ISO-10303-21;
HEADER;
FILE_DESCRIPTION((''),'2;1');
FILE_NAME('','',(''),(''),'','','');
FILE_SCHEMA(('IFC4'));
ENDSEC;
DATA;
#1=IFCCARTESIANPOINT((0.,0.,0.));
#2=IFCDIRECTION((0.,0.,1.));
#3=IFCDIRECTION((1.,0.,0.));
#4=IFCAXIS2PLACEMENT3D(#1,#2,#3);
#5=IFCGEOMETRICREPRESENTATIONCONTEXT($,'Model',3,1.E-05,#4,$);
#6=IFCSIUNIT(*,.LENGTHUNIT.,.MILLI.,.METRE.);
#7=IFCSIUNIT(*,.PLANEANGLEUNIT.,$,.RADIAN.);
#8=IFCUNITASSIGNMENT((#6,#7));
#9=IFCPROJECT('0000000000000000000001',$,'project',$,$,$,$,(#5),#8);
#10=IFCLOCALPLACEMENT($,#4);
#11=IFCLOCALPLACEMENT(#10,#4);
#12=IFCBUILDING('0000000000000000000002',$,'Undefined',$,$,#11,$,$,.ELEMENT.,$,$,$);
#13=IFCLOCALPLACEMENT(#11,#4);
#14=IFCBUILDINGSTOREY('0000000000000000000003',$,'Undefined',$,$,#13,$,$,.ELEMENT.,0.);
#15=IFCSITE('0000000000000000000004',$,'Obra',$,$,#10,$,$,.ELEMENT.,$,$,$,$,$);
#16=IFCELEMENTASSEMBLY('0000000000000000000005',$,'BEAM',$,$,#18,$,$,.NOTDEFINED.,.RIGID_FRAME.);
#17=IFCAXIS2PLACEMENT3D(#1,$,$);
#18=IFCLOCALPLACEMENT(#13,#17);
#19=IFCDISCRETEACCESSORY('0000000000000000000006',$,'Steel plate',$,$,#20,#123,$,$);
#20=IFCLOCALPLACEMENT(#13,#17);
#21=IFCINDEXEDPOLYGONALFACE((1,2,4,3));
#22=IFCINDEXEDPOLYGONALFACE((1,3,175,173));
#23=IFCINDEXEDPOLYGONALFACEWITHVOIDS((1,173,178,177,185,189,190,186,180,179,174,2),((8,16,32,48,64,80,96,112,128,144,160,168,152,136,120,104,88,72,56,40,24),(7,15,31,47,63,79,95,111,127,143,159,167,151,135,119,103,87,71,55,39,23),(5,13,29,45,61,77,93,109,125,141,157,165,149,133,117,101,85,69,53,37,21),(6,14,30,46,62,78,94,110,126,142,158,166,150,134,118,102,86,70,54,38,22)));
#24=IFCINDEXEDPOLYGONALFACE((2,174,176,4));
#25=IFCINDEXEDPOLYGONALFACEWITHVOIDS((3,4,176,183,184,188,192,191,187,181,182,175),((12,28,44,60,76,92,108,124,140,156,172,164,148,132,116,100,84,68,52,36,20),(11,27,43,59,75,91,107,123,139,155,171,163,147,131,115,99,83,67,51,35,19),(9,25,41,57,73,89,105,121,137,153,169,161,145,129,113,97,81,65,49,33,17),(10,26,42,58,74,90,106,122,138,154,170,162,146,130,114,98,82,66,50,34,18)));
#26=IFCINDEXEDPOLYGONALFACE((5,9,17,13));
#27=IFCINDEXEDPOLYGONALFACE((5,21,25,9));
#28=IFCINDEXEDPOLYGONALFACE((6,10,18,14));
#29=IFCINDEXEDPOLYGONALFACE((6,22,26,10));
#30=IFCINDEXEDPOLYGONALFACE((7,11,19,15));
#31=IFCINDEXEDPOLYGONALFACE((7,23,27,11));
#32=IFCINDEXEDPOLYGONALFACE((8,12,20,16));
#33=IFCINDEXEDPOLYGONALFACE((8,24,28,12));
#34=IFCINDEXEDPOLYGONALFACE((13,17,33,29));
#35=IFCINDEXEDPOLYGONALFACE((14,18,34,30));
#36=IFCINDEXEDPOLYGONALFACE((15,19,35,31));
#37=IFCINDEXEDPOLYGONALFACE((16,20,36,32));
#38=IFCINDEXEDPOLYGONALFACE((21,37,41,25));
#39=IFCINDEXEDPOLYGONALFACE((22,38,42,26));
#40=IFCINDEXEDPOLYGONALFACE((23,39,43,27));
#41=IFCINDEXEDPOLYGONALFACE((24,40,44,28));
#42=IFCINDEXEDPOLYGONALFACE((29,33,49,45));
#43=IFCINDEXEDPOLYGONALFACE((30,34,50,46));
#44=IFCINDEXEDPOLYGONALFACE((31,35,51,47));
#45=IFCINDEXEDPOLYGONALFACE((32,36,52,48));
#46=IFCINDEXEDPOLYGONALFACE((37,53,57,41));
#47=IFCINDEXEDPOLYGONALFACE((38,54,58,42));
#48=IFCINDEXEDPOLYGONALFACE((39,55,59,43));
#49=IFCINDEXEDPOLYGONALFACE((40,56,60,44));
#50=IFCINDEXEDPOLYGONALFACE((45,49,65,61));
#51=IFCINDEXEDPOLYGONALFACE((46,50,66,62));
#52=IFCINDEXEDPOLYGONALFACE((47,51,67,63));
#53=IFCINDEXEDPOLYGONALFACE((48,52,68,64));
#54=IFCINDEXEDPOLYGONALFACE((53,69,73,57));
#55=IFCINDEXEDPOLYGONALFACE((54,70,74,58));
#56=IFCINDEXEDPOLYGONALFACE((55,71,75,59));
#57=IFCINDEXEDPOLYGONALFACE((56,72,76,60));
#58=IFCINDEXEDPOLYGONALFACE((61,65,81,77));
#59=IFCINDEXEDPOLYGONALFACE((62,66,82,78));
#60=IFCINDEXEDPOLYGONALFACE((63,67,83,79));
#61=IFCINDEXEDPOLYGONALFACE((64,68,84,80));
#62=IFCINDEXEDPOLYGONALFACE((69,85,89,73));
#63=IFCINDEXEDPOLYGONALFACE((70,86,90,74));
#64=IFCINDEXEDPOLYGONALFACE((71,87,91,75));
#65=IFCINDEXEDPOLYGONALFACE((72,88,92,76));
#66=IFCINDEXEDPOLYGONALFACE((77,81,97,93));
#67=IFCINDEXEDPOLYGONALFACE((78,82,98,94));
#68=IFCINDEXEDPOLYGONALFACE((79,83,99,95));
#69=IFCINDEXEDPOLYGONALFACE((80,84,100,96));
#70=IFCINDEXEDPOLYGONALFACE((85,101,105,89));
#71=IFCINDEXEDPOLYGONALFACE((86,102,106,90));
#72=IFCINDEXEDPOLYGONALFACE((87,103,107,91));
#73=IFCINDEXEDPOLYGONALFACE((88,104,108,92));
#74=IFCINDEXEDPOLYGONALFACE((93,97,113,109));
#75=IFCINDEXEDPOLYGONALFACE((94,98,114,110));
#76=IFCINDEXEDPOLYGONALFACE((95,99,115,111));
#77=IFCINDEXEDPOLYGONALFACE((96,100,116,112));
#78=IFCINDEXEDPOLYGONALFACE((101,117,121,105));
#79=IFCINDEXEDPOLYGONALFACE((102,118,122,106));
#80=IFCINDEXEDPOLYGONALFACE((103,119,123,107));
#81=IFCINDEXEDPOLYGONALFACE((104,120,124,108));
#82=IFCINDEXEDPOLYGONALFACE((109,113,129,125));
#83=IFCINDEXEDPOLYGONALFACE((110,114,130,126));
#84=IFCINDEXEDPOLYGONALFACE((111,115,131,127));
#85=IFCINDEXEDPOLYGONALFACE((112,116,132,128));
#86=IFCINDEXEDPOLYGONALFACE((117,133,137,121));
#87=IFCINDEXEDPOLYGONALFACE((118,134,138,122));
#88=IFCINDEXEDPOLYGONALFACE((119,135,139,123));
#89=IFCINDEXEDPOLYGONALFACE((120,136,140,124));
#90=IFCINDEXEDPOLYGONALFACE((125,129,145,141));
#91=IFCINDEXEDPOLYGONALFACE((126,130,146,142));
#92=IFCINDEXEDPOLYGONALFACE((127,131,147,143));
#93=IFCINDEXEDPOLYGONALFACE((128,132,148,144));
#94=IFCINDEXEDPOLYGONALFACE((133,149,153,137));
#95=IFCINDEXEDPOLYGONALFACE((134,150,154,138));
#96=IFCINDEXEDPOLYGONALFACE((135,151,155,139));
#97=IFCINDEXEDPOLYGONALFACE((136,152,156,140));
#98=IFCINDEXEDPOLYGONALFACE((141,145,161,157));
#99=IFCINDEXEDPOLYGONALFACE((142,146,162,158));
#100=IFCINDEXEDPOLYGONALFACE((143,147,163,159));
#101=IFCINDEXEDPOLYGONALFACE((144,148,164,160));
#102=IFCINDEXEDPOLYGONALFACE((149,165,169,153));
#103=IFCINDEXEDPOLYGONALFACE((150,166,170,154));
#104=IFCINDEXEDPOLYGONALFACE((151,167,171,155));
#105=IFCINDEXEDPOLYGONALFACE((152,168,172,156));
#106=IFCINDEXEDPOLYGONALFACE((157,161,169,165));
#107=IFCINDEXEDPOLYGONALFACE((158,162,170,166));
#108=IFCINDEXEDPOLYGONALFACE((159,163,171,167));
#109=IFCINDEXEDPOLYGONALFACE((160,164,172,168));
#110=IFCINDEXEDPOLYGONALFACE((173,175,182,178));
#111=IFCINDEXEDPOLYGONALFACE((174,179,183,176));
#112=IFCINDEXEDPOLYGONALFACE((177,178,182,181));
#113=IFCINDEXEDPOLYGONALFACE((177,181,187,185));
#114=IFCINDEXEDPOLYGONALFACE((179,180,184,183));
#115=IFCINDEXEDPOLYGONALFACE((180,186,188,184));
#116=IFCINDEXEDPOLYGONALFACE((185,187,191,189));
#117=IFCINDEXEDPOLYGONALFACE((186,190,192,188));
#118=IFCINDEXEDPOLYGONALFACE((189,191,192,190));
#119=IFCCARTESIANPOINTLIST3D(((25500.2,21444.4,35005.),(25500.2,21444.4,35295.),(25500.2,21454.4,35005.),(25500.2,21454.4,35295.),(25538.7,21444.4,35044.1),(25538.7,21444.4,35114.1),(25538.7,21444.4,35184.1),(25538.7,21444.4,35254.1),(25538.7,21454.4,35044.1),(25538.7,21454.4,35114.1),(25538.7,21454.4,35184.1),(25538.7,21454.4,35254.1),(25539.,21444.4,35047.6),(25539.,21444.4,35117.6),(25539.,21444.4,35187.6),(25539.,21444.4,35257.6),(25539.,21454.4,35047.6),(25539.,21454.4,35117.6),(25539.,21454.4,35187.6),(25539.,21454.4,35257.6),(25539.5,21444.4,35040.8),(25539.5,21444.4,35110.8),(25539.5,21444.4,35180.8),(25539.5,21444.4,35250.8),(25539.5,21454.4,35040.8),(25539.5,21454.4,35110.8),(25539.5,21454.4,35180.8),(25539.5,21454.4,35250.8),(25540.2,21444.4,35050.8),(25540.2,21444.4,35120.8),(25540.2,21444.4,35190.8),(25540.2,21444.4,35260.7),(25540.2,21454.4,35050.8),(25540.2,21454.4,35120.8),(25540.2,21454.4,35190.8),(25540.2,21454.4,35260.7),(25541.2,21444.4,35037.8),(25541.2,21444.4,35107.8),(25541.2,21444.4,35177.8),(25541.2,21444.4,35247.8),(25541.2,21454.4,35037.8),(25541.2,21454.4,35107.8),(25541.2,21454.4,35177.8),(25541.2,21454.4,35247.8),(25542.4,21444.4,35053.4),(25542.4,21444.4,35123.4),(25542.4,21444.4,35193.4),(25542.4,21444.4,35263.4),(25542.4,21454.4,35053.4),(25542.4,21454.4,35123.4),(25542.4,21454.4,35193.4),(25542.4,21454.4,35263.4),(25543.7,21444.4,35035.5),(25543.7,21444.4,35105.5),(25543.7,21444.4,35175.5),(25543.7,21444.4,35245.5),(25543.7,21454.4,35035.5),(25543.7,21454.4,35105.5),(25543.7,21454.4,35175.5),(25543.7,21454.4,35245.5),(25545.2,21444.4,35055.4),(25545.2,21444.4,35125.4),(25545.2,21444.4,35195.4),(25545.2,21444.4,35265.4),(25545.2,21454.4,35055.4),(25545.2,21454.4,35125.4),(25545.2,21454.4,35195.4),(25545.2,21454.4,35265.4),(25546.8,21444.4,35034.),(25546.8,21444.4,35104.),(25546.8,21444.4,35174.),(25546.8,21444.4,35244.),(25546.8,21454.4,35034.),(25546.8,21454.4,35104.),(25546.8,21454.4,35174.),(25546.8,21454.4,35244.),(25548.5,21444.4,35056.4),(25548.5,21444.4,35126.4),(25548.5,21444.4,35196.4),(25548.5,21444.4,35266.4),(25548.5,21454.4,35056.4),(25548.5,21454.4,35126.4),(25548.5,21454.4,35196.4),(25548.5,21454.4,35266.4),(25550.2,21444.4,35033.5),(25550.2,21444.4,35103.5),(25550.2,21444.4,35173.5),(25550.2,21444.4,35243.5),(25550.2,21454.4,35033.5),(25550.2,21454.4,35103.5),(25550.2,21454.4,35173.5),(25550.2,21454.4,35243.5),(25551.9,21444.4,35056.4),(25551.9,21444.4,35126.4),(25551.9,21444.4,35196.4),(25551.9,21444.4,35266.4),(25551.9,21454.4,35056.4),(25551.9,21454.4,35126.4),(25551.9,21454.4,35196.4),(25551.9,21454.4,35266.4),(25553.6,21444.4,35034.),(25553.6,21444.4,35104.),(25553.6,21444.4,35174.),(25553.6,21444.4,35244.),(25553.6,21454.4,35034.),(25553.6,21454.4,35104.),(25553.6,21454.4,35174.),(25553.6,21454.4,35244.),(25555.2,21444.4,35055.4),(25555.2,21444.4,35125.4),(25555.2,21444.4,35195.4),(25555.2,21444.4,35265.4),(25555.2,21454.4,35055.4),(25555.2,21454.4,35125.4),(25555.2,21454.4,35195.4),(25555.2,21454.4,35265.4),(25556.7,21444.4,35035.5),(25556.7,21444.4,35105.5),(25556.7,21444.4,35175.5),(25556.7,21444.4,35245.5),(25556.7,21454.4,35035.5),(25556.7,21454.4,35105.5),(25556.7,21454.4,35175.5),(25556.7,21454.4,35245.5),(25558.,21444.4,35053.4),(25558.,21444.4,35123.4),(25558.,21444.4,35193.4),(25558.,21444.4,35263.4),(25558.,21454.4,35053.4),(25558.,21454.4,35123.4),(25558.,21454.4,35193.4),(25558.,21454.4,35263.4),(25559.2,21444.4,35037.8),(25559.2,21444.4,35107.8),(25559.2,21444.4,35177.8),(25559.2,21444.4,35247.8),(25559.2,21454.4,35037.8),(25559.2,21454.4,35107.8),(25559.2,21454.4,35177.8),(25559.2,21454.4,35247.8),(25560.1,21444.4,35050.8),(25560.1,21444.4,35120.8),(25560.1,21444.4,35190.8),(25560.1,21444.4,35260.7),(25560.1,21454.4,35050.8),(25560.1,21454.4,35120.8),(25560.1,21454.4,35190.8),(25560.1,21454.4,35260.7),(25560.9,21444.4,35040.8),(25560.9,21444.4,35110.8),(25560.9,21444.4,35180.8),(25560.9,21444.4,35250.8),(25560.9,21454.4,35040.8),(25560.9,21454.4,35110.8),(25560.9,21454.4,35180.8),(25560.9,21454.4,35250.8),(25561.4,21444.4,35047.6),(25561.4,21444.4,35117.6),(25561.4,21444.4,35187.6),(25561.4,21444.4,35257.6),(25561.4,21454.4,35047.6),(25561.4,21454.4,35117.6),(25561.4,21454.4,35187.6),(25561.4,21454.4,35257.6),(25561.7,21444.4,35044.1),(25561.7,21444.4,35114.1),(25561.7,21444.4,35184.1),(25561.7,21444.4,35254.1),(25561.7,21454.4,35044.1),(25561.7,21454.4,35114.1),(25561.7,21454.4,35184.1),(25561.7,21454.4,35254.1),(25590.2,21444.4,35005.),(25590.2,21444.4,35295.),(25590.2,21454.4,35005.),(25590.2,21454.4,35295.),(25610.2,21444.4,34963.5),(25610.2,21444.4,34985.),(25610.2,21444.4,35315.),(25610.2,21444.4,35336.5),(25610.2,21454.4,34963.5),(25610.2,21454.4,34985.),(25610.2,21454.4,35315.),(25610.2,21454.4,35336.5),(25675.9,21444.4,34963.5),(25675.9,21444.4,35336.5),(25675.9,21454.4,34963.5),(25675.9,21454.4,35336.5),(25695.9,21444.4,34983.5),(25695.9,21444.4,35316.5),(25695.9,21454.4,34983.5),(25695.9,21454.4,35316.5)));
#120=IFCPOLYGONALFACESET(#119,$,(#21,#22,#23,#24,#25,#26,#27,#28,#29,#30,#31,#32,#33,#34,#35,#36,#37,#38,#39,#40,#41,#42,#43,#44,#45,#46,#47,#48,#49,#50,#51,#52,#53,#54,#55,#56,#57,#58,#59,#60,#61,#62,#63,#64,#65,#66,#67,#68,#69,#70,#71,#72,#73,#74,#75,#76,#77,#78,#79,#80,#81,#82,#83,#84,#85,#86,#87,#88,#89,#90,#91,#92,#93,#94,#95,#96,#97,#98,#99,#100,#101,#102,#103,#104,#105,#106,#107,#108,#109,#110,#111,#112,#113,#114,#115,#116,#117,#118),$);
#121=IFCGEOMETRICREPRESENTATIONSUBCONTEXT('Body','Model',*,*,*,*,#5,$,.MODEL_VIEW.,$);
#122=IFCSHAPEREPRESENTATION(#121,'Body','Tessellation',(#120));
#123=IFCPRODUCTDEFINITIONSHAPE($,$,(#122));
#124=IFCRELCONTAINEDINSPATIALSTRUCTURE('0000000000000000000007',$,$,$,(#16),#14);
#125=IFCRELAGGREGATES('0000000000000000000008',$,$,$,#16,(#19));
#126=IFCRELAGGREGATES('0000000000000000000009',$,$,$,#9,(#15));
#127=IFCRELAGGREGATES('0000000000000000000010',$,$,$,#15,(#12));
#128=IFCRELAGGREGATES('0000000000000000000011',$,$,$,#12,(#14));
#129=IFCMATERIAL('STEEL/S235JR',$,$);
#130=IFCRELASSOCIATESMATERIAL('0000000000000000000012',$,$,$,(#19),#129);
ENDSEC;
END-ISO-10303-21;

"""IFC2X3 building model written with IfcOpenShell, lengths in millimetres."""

from ifc_helpers import new_model, si_unit, frame, origin_with_axes, origin_2d_with_axis, place, context, subcontext, project, spatial, polyline, circle, outline, extrude, source, transform, mapped, material, element, aggregate, save


model = new_model("IFC2X3")

# Units and contexts
model_context = context("Model", 3, precision=1e-05, world=origin_with_axes())
body_context = subcontext(model_context, "Body", "Model", "MODEL_VIEW")
ifc_project = project(units=[si_unit("LENGTHUNIT", "METRE", prefix="MILLI"), si_unit("PLANEANGLEUNIT", "RADIAN")], contexts=[model_context])

# Site, building, storey
site_placement = place(None, origin_with_axes())
site = spatial("IfcSite", under=ifc_project, at=site_placement, Name="Obra", CompositionType="ELEMENT")
building_placement = place(site_placement, origin_with_axes())
building = spatial("IfcBuilding", under=site, at=building_placement, Name="Undefined", CompositionType="ELEMENT")
storey_placement = place(building_placement, origin_with_axes())
storey = spatial("IfcBuildingStorey", under=building, at=storey_placement, Name="Undefined", CompositionType="ELEMENT", Elevation=0.0)

# Element assembly
assembly_1_placement = place(storey_placement, origin_with_axes())
assembly_1 = element("IfcElementAssembly", 1, at=assembly_1_placement, inside=storey, Name="BEAM", AssemblyPlace="NOTDEFINED", PredefinedType="RIGID_FRAME")
ifc_material_1 = material(Name="STEEL/S235JR")

# Shared definitions
shared_shape_1 = source(origin_with_axes(), body_context, "Body", "SweptSolid", [
    extrude(circle(Radius=11.5, at=origin_2d_with_axis()), frame((0.0, -14.4, 0.0), z_axis=(0.0, 1.0, 0.0), x_axis=(1.0, 0.0, 0.0)), (0.0, 0.0, 1.0), 10.2),
])

# Discrete accessory, opening
discrete_accessory_1_placement = place(assembly_1_placement, frame((25695.9, 21449.4, 34983.5), z_axis=(0.0, 1.0, 0.0), x_axis=(-0.707107, 0.0, -0.707107)))
discrete_accessory_1 = element("IfcDiscreteAccessory", 2, at=discrete_accessory_1_placement, material=ifc_material_1, Name="Steel plate", context=body_context, shape_type="SweptSolid", body=[
    extrude(outline(polyline([(0.0, 0.0), (28.3, 0.0), (74.7, 46.5), (59.5, 61.7), (59.5, 89.9), (123.2, 153.6), (-81.9, 358.6), (-145.5, 295.0), (-173.8, 295.0), (-189.0, 310.2), (-235.5, 263.8), (-235.5, 235.5), (0.0, 0.0)])), frame((0.0, 0.0, -5.0), z_axis=(0.0, 0.0, 1.0), x_axis=(1.0, 0.0, 0.0)), (0.0, 0.0, 1.0), 10.0),
])
opening_1_placement = place(assembly_1_placement, frame((25600.2, 21440.1, 35295.0), z_axis=(-1.0, 0.0, 0.0), x_axis=(0.0, 0.0, -1.0)))
element("IfcOpeningElement", 3, at=opening_1_placement, cuts=discrete_accessory_1, ObjectType="Opening", context=body_context, shape_type="MappedRepresentation", body=[
    mapped(shared_shape_1, transform((40.0, 0.0, 50.0))),
    mapped(shared_shape_1, transform((110.0, 0.0, 50.0))),
    mapped(shared_shape_1, transform((180.0, 0.0, 50.0))),
    mapped(shared_shape_1, transform((250.0, 0.0, 50.0))),
])
aggregate(assembly_1, [discrete_accessory_1])

save(model, "model.ifc")
